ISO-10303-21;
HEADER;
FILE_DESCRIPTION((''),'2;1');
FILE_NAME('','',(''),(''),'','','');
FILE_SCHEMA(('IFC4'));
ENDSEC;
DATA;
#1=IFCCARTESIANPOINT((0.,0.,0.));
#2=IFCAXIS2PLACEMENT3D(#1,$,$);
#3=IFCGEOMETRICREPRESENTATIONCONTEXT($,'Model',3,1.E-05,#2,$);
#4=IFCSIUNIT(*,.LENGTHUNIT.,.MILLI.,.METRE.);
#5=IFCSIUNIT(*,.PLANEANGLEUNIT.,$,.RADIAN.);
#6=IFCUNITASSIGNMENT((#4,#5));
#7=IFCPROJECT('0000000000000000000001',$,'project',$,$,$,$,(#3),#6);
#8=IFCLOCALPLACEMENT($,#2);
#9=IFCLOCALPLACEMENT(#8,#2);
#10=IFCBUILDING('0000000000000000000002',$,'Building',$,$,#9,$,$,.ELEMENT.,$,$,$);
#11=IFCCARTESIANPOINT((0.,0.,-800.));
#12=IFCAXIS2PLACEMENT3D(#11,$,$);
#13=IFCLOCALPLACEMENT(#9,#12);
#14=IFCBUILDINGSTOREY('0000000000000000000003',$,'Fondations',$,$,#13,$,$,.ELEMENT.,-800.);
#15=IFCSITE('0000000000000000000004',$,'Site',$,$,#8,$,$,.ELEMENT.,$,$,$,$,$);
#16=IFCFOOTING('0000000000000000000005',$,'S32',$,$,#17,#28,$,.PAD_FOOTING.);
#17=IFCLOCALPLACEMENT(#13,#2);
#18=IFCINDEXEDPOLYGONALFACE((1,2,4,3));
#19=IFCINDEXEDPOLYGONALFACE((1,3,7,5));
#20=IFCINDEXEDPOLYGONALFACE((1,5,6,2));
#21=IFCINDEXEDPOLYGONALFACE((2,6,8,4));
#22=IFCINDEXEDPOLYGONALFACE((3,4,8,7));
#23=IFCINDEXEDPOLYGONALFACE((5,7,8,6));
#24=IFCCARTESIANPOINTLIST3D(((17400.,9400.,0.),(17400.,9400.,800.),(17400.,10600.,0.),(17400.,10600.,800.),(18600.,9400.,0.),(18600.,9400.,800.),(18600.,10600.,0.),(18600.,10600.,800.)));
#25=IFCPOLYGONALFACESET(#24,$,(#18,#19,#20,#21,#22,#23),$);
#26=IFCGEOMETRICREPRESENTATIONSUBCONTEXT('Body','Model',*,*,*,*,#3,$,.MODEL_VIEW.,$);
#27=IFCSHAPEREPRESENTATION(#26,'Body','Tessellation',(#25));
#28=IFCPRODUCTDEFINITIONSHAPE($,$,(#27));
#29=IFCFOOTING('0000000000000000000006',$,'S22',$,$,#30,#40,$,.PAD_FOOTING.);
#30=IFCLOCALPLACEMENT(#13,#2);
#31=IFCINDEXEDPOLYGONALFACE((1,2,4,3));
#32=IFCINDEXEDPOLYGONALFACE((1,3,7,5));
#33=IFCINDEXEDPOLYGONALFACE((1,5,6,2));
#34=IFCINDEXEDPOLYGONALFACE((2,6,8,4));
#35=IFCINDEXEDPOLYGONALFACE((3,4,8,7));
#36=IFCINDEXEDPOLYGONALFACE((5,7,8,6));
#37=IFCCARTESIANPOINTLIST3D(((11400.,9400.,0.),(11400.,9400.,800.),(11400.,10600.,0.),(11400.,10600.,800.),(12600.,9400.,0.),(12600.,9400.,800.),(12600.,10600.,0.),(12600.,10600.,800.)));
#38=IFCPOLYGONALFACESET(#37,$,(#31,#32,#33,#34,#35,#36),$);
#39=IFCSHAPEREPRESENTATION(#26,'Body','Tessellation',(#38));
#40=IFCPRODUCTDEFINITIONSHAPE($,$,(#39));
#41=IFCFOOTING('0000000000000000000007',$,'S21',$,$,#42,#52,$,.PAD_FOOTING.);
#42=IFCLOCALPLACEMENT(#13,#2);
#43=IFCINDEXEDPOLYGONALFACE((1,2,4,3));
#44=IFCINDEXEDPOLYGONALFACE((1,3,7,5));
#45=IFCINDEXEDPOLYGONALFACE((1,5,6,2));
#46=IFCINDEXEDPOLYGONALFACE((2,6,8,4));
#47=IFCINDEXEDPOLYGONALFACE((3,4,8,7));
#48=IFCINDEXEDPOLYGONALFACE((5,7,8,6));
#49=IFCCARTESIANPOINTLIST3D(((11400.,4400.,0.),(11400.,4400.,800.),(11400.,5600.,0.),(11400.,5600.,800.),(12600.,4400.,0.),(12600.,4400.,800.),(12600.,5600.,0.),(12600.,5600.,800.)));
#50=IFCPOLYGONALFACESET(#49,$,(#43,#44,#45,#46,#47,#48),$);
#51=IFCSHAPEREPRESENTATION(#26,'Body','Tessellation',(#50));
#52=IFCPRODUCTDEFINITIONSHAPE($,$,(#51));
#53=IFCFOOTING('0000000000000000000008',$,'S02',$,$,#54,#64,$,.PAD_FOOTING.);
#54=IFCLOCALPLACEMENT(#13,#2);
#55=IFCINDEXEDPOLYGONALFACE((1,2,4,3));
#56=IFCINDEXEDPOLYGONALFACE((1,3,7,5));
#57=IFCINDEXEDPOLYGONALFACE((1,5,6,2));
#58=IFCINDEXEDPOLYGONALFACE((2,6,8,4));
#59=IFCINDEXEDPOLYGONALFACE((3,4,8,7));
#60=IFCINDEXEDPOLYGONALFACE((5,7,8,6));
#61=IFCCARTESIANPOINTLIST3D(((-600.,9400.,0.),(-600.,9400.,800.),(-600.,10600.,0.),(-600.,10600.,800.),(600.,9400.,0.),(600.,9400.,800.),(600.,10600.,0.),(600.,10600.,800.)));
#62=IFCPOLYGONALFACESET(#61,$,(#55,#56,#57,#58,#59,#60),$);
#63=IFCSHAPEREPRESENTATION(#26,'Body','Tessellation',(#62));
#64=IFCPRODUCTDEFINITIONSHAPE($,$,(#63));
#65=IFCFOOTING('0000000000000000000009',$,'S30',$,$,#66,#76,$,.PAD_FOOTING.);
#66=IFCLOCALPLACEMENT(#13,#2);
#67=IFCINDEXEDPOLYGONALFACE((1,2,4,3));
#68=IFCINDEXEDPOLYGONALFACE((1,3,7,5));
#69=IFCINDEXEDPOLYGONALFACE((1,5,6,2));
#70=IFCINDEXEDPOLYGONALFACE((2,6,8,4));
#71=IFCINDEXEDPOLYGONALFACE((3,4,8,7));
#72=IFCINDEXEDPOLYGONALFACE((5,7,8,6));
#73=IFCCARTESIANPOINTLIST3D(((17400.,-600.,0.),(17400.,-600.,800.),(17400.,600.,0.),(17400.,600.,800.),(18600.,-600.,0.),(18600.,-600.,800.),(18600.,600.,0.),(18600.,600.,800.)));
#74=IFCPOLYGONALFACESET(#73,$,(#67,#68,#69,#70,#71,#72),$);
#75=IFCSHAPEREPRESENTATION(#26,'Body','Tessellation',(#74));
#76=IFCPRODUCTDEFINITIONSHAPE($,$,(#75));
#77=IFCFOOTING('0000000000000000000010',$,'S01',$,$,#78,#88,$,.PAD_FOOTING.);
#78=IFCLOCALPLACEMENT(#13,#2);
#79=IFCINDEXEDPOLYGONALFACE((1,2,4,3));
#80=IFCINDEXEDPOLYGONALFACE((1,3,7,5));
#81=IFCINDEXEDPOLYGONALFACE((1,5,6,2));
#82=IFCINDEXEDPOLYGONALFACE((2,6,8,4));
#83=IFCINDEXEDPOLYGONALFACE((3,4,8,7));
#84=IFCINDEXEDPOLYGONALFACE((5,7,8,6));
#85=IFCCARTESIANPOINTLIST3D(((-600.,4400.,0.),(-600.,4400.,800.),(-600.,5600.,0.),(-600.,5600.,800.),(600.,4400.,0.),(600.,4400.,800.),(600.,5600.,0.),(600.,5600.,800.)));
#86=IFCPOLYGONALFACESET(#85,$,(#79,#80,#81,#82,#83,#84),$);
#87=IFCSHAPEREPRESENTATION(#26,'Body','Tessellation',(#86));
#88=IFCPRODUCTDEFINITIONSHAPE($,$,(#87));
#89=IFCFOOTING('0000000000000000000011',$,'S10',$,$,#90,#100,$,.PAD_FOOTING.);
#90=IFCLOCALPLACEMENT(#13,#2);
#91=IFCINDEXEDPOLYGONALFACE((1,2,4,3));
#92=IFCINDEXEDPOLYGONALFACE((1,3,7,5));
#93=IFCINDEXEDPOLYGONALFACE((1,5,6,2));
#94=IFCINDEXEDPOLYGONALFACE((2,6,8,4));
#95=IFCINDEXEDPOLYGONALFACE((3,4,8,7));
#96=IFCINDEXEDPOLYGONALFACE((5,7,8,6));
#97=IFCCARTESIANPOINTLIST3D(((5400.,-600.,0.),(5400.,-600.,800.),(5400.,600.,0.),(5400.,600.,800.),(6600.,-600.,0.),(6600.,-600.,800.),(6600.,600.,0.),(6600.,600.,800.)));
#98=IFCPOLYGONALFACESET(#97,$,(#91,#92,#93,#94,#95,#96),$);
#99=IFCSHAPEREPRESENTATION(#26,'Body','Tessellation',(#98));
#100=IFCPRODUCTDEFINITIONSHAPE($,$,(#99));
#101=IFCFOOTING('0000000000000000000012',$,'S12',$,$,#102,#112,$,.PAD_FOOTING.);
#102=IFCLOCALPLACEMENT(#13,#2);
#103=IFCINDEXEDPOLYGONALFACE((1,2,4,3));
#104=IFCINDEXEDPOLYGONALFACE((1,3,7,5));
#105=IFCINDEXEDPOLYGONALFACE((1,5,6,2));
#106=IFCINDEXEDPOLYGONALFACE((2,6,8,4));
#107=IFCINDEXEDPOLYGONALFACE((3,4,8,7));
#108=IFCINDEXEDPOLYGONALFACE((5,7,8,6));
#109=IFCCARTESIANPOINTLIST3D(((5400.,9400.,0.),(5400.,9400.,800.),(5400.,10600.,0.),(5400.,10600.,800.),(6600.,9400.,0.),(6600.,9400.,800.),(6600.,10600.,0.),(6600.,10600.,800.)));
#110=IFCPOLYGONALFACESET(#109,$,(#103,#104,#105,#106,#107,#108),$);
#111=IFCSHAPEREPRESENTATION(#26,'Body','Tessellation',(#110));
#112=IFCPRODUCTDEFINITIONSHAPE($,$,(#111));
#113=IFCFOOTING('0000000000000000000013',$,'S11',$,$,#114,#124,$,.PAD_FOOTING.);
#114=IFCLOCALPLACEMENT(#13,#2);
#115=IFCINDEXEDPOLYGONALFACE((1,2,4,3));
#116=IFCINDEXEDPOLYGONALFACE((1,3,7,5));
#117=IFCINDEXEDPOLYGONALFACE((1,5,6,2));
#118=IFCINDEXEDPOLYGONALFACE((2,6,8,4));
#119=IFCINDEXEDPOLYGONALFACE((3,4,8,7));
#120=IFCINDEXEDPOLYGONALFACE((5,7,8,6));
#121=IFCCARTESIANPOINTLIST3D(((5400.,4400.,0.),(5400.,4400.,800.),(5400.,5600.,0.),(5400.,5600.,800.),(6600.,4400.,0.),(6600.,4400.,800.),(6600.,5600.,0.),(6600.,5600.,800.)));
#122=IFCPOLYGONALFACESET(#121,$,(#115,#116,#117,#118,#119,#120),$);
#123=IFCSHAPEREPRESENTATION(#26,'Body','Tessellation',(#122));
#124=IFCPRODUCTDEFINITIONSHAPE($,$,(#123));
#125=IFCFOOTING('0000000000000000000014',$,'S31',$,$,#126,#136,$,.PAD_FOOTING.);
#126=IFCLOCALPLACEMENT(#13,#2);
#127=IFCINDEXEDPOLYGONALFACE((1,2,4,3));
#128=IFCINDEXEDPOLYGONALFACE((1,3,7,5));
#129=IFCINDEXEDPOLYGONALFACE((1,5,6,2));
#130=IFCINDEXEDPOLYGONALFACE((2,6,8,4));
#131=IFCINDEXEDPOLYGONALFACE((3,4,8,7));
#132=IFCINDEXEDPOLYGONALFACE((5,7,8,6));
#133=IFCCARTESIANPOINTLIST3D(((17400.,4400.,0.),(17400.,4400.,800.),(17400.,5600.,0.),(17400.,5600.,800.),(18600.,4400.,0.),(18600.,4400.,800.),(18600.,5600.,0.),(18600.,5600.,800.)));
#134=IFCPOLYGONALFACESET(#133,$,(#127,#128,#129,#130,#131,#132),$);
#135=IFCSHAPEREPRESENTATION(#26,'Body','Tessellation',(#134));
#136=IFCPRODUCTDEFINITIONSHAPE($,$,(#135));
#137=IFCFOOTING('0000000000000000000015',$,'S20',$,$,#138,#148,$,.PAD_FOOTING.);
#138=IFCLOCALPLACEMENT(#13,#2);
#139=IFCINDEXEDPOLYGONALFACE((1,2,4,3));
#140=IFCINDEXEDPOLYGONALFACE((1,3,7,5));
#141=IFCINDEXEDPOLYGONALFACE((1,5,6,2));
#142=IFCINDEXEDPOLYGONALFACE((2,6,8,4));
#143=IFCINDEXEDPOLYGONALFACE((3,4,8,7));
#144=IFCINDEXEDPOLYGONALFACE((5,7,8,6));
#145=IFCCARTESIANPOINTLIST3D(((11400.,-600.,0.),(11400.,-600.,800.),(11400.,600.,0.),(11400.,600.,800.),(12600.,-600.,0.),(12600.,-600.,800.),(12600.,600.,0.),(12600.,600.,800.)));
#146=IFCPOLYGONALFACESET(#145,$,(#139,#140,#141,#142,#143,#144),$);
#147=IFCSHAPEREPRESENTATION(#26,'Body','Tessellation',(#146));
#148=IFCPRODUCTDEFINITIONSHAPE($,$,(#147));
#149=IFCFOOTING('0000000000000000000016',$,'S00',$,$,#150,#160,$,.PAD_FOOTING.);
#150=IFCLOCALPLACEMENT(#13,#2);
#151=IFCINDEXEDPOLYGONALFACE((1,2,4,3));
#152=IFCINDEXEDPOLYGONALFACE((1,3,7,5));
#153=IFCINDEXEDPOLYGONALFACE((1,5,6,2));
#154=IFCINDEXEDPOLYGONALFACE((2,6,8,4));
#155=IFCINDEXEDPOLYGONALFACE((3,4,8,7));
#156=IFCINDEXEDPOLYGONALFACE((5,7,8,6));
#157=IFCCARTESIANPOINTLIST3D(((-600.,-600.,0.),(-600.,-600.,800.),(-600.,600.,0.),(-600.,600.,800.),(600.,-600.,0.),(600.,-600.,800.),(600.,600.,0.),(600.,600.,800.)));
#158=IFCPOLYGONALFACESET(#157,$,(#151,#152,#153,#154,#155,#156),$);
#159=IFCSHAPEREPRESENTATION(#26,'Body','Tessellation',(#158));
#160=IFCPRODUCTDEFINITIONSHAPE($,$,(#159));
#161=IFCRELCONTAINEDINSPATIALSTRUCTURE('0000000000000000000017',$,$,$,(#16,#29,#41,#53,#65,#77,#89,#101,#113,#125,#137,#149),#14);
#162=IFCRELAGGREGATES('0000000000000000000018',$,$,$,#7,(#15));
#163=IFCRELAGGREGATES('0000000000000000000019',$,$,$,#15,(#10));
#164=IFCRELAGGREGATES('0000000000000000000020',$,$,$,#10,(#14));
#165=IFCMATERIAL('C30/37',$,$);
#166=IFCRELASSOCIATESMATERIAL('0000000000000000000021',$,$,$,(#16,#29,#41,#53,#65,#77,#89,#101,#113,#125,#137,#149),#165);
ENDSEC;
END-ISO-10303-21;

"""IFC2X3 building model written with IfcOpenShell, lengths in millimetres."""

from ifc_helpers import new_model, si_unit, frame, origin, origin_2d, place, context, subcontext, project, spatial, rectangle, extrude, material, element, save


model = new_model("IFC2X3")

# Units and contexts
model_context = context("Model", 3, precision=1e-05, world=origin())
body_context = subcontext(model_context, "Body", "Model", "MODEL_VIEW")
ifc_project = project(units=[si_unit("LENGTHUNIT", "METRE", prefix="MILLI"), si_unit("PLANEANGLEUNIT", "RADIAN")], contexts=[model_context])

# Site, building, storey
site_placement = place(None, origin())
site = spatial("IfcSite", under=ifc_project, at=site_placement, Name="Site", CompositionType="ELEMENT")
building_placement = place(site_placement, origin())
building = spatial("IfcBuilding", under=site, at=building_placement, Name="Building", CompositionType="ELEMENT")
storey_placement = place(building_placement, frame((0.0, 0.0, -800.0)))
storey = spatial("IfcBuildingStorey", under=building, at=storey_placement, Name="Fondations", CompositionType="ELEMENT", Elevation=-800.0)

# Footings
ifc_material = material(Name="C30/37")
for number, where, z_axis, x_axis, name in (
    (1, (18000.0, 10000.0, 0.0), (0.0, 0.0, 1.0), (1.0, 0.0, 0.0), "S32"),
    (2, (12000.0, 10000.0, 0.0), (0.0, 0.0, 1.0), (1.0, 0.0, 0.0), "S22"),
    (3, (12000.0, 5000.0, 0.0), (0.0, 0.0, 1.0), (1.0, 0.0, 0.0), "S21"),
    (4, (0.0, 10000.0, 0.0), (0.0, 0.0, 1.0), (1.0, 0.0, 0.0), "S02"),
    (5, (18000.0, 0.0, 0.0), (0.0, 0.0, 1.0), (1.0, 0.0, 0.0), "S30"),
    (6, (0.0, 5000.0, 0.0), (0.0, 0.0, 1.0), (1.0, 0.0, 0.0), "S01"),
    (7, (6000.0, 0.0, 0.0), (0.0, 0.0, 1.0), (1.0, 0.0, 0.0), "S10"),
    (8, (6000.0, 10000.0, 0.0), (0.0, 0.0, 1.0), (1.0, 0.0, 0.0), "S12"),
    (9, (6000.0, 5000.0, 0.0), (0.0, 0.0, 1.0), (1.0, 0.0, 0.0), "S11"),
    (10, (18000.0, 5000.0, 0.0), (0.0, 0.0, 1.0), (1.0, 0.0, 0.0), "S31"),
    (11, (12000.0, 0.0, 0.0), (0.0, 0.0, 1.0), (1.0, 0.0, 0.0), "S20"),
    (12, (0.0, 0.0, 0.0), (0.0, 0.0, 1.0), (1.0, 0.0, 0.0), "S00"),
):
    element("IfcFooting", number, at=place(storey_placement, frame(where, z_axis=z_axis, x_axis=x_axis)), inside=storey, material=ifc_material, Name=name, PredefinedType="PAD_FOOTING", context=body_context, shape_type="SweptSolid", body=[
        extrude(rectangle(XDim=1200.0, YDim=1200.0, at=origin_2d()), origin(), (0.0, 0.0, 1.0), 800.0),
    ])

save(model, "model.ifc")
